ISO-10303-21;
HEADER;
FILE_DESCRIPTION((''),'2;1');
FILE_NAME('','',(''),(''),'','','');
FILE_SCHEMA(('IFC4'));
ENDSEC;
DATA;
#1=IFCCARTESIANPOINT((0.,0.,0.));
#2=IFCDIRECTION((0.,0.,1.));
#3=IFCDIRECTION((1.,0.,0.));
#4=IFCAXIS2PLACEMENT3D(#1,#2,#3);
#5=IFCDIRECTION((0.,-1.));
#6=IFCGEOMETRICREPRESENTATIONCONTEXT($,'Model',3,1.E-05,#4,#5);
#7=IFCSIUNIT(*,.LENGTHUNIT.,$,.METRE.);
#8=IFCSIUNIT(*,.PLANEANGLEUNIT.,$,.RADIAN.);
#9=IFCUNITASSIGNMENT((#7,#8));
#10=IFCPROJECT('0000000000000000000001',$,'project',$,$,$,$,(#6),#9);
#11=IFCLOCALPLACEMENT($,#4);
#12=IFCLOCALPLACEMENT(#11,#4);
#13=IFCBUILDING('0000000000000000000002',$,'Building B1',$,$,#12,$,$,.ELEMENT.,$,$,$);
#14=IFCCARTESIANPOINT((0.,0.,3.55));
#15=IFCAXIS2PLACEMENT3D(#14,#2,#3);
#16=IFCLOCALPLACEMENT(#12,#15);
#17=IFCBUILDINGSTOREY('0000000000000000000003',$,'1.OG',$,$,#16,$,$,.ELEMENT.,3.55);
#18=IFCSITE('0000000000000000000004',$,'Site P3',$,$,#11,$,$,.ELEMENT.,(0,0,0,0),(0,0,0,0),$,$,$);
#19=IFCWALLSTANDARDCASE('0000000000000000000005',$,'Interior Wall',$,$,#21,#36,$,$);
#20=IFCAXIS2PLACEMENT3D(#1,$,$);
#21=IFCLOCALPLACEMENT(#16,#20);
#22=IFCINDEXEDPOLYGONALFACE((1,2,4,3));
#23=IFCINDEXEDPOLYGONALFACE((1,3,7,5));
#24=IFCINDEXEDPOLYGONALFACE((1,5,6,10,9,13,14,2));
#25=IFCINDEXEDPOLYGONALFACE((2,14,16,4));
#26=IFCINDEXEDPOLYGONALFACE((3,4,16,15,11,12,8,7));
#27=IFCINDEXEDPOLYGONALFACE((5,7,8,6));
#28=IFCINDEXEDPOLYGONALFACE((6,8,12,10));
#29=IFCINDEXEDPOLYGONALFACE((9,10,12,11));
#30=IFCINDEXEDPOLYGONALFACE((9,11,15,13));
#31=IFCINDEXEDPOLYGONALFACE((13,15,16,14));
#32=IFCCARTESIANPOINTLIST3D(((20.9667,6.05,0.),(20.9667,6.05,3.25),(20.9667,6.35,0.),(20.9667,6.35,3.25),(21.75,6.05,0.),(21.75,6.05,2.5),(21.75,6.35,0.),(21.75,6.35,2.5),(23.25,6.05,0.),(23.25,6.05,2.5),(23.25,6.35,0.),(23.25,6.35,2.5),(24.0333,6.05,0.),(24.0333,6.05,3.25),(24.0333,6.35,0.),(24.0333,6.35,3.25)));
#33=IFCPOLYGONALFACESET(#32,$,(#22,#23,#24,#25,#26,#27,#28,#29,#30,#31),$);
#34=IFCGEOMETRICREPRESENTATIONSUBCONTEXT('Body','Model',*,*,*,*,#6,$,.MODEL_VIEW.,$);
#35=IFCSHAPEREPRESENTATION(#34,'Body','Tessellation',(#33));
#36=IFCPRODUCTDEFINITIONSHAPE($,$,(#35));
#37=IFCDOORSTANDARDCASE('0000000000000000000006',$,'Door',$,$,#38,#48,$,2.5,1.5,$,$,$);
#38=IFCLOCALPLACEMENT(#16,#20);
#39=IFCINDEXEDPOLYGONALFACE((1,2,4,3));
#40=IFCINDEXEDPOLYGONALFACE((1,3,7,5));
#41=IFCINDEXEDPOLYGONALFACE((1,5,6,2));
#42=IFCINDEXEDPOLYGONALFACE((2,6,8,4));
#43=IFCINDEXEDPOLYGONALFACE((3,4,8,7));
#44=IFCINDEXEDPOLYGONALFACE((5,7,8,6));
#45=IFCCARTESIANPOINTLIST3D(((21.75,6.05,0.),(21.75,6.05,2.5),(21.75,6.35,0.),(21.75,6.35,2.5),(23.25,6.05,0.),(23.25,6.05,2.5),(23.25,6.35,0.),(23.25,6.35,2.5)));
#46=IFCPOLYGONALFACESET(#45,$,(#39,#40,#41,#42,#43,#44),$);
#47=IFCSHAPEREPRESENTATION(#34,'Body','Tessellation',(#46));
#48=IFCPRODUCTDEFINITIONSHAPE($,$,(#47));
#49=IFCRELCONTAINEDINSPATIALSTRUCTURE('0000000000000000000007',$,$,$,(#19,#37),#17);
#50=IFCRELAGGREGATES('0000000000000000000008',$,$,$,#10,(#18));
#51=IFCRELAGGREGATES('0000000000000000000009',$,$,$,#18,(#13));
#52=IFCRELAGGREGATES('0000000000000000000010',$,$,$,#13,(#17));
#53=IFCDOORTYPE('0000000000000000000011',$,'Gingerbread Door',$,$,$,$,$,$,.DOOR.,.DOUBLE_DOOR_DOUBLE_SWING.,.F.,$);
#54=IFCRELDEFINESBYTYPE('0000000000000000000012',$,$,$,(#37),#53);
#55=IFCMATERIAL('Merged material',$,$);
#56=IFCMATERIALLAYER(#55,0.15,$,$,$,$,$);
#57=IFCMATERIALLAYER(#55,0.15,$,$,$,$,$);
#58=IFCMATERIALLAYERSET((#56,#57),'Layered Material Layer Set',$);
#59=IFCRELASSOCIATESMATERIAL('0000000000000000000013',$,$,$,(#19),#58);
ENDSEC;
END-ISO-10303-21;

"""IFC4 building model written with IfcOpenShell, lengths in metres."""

from ifc_helpers import new_model, si_unit, direction, frame, origin_with_axes, place, context, subcontext, project, spatial, polyline, outline, extrude, source, transform, mapped, material, layer, layer_set, layer_usage, type_object, element, fill, save


model = new_model("IFC4")

# Units and contexts
model_context = context("Model", 3, precision=1e-05, world=origin_with_axes(), true_north=direction((0.0, -1.0)))
body_context = subcontext(model_context, "Body", "Model", "MODEL_VIEW")
ifc_project = project(units=[si_unit("LENGTHUNIT", "METRE"), si_unit("PLANEANGLEUNIT", "RADIAN")], contexts=[model_context])

# Site, building, storey
site_placement = place(None, origin_with_axes())
site = spatial("IfcSite", under=ifc_project, at=site_placement, Name="Site P3", CompositionType="ELEMENT", RefLatitude=(0, 0, 0, 0), RefLongitude=(0, 0, 0, 0))
building_placement = place(site_placement, origin_with_axes())
building = spatial("IfcBuilding", under=site, at=building_placement, Name="Building B1", CompositionType="ELEMENT")
storey_placement = place(building_placement, frame((0.0, 0.0, 3.55), z_axis=(0.0, 0.0, 1.0), x_axis=(1.0, 0.0, 0.0)))
storey = spatial("IfcBuildingStorey", under=building, at=storey_placement, Name="1.OG", CompositionType="ELEMENT", Elevation=3.55)

# Shared definitions
ifc_material = material(Name="Merged material")
ifc_layer_1 = layer(ifc_material, 0.15)
ifc_layer_2 = layer(ifc_material, 0.15)
ifc_layer_set = layer_set([ifc_layer_1, ifc_layer_2], Name="Layered Material Layer Set")
ifc_layer_usage = layer_usage(ifc_layer_set, "AXIS2", "POSITIVE", -0.15)
door_type = type_object("IfcDoorType", Name="Gingerbread Door", OperationType="DOUBLE_DOOR_DOUBLE_SWING", ParameterTakesPrecedence=False, PredefinedType="DOOR")
shared_shape = source(origin_with_axes(), body_context, "Body", "SweptSolid", [
    extrude(outline(polyline([(0.0, 0.0), (0.0, 1.5), (2.5, 1.5), (2.5, 0.0), (0.0, 0.0)])), frame((0.0, -0.15, 0.0), z_axis=(0.0, 1.0, 0.0), x_axis=(0.0, 0.0, 1.0)), (0.0, 0.0, 1.0), 0.3),
])

# Wall, opening, door
wall_1_placement = place(storey_placement, frame((20.9667, 6.2, 0.0), z_axis=(0.0, 0.0, 1.0), x_axis=(1.0, 0.0, 0.0)))
wall_1 = element("IfcWallStandardCase", 1, at=wall_1_placement, inside=storey, material=ifc_layer_usage, Name="Interior Wall", context=body_context, shape_type="SweptSolid", body=[
    extrude(outline(polyline([(0.0, 0.15), (3.0667, 0.15), (3.0667, -0.15), (0.0, -0.15), (0.0, 0.15)])), origin_with_axes(), (0.0, 0.0, 1.0), 3.25),
])
opening_1_placement = place(wall_1_placement, frame((0.7833, 0.0, 0.0), z_axis=(0.0, 0.0, 1.0), x_axis=(1.0, 0.0, 0.0)))
opening_1 = element("IfcOpeningStandardCase", 2, at=opening_1_placement, cuts=wall_1, context=body_context, shape_type="SweptSolid", body=[
    extrude(outline(polyline([(0.0, 0.0), (0.0, 1.5), (2.5, 1.5), (2.5, 0.0), (0.0, 0.0)])), frame((0.0, -0.15, 0.0), z_axis=(0.0, 1.0, 0.0), x_axis=(0.0, 0.0, 1.0)), (0.0, 0.0, 1.0), 0.3),
])
door_1_placement = place(opening_1_placement, origin_with_axes())
door_1 = element("IfcDoorStandardCase", 3, at=door_1_placement, inside=storey, type_object=door_type, Name="Door", OverallHeight=2.5, OverallWidth=1.5, context=body_context, shape_type="MappedRepresentation", body=[
    mapped(shared_shape, transform((0.0, 0.0, 0.0))),
])
fill(opening_1, door_1)

save(model, "model.ifc")
